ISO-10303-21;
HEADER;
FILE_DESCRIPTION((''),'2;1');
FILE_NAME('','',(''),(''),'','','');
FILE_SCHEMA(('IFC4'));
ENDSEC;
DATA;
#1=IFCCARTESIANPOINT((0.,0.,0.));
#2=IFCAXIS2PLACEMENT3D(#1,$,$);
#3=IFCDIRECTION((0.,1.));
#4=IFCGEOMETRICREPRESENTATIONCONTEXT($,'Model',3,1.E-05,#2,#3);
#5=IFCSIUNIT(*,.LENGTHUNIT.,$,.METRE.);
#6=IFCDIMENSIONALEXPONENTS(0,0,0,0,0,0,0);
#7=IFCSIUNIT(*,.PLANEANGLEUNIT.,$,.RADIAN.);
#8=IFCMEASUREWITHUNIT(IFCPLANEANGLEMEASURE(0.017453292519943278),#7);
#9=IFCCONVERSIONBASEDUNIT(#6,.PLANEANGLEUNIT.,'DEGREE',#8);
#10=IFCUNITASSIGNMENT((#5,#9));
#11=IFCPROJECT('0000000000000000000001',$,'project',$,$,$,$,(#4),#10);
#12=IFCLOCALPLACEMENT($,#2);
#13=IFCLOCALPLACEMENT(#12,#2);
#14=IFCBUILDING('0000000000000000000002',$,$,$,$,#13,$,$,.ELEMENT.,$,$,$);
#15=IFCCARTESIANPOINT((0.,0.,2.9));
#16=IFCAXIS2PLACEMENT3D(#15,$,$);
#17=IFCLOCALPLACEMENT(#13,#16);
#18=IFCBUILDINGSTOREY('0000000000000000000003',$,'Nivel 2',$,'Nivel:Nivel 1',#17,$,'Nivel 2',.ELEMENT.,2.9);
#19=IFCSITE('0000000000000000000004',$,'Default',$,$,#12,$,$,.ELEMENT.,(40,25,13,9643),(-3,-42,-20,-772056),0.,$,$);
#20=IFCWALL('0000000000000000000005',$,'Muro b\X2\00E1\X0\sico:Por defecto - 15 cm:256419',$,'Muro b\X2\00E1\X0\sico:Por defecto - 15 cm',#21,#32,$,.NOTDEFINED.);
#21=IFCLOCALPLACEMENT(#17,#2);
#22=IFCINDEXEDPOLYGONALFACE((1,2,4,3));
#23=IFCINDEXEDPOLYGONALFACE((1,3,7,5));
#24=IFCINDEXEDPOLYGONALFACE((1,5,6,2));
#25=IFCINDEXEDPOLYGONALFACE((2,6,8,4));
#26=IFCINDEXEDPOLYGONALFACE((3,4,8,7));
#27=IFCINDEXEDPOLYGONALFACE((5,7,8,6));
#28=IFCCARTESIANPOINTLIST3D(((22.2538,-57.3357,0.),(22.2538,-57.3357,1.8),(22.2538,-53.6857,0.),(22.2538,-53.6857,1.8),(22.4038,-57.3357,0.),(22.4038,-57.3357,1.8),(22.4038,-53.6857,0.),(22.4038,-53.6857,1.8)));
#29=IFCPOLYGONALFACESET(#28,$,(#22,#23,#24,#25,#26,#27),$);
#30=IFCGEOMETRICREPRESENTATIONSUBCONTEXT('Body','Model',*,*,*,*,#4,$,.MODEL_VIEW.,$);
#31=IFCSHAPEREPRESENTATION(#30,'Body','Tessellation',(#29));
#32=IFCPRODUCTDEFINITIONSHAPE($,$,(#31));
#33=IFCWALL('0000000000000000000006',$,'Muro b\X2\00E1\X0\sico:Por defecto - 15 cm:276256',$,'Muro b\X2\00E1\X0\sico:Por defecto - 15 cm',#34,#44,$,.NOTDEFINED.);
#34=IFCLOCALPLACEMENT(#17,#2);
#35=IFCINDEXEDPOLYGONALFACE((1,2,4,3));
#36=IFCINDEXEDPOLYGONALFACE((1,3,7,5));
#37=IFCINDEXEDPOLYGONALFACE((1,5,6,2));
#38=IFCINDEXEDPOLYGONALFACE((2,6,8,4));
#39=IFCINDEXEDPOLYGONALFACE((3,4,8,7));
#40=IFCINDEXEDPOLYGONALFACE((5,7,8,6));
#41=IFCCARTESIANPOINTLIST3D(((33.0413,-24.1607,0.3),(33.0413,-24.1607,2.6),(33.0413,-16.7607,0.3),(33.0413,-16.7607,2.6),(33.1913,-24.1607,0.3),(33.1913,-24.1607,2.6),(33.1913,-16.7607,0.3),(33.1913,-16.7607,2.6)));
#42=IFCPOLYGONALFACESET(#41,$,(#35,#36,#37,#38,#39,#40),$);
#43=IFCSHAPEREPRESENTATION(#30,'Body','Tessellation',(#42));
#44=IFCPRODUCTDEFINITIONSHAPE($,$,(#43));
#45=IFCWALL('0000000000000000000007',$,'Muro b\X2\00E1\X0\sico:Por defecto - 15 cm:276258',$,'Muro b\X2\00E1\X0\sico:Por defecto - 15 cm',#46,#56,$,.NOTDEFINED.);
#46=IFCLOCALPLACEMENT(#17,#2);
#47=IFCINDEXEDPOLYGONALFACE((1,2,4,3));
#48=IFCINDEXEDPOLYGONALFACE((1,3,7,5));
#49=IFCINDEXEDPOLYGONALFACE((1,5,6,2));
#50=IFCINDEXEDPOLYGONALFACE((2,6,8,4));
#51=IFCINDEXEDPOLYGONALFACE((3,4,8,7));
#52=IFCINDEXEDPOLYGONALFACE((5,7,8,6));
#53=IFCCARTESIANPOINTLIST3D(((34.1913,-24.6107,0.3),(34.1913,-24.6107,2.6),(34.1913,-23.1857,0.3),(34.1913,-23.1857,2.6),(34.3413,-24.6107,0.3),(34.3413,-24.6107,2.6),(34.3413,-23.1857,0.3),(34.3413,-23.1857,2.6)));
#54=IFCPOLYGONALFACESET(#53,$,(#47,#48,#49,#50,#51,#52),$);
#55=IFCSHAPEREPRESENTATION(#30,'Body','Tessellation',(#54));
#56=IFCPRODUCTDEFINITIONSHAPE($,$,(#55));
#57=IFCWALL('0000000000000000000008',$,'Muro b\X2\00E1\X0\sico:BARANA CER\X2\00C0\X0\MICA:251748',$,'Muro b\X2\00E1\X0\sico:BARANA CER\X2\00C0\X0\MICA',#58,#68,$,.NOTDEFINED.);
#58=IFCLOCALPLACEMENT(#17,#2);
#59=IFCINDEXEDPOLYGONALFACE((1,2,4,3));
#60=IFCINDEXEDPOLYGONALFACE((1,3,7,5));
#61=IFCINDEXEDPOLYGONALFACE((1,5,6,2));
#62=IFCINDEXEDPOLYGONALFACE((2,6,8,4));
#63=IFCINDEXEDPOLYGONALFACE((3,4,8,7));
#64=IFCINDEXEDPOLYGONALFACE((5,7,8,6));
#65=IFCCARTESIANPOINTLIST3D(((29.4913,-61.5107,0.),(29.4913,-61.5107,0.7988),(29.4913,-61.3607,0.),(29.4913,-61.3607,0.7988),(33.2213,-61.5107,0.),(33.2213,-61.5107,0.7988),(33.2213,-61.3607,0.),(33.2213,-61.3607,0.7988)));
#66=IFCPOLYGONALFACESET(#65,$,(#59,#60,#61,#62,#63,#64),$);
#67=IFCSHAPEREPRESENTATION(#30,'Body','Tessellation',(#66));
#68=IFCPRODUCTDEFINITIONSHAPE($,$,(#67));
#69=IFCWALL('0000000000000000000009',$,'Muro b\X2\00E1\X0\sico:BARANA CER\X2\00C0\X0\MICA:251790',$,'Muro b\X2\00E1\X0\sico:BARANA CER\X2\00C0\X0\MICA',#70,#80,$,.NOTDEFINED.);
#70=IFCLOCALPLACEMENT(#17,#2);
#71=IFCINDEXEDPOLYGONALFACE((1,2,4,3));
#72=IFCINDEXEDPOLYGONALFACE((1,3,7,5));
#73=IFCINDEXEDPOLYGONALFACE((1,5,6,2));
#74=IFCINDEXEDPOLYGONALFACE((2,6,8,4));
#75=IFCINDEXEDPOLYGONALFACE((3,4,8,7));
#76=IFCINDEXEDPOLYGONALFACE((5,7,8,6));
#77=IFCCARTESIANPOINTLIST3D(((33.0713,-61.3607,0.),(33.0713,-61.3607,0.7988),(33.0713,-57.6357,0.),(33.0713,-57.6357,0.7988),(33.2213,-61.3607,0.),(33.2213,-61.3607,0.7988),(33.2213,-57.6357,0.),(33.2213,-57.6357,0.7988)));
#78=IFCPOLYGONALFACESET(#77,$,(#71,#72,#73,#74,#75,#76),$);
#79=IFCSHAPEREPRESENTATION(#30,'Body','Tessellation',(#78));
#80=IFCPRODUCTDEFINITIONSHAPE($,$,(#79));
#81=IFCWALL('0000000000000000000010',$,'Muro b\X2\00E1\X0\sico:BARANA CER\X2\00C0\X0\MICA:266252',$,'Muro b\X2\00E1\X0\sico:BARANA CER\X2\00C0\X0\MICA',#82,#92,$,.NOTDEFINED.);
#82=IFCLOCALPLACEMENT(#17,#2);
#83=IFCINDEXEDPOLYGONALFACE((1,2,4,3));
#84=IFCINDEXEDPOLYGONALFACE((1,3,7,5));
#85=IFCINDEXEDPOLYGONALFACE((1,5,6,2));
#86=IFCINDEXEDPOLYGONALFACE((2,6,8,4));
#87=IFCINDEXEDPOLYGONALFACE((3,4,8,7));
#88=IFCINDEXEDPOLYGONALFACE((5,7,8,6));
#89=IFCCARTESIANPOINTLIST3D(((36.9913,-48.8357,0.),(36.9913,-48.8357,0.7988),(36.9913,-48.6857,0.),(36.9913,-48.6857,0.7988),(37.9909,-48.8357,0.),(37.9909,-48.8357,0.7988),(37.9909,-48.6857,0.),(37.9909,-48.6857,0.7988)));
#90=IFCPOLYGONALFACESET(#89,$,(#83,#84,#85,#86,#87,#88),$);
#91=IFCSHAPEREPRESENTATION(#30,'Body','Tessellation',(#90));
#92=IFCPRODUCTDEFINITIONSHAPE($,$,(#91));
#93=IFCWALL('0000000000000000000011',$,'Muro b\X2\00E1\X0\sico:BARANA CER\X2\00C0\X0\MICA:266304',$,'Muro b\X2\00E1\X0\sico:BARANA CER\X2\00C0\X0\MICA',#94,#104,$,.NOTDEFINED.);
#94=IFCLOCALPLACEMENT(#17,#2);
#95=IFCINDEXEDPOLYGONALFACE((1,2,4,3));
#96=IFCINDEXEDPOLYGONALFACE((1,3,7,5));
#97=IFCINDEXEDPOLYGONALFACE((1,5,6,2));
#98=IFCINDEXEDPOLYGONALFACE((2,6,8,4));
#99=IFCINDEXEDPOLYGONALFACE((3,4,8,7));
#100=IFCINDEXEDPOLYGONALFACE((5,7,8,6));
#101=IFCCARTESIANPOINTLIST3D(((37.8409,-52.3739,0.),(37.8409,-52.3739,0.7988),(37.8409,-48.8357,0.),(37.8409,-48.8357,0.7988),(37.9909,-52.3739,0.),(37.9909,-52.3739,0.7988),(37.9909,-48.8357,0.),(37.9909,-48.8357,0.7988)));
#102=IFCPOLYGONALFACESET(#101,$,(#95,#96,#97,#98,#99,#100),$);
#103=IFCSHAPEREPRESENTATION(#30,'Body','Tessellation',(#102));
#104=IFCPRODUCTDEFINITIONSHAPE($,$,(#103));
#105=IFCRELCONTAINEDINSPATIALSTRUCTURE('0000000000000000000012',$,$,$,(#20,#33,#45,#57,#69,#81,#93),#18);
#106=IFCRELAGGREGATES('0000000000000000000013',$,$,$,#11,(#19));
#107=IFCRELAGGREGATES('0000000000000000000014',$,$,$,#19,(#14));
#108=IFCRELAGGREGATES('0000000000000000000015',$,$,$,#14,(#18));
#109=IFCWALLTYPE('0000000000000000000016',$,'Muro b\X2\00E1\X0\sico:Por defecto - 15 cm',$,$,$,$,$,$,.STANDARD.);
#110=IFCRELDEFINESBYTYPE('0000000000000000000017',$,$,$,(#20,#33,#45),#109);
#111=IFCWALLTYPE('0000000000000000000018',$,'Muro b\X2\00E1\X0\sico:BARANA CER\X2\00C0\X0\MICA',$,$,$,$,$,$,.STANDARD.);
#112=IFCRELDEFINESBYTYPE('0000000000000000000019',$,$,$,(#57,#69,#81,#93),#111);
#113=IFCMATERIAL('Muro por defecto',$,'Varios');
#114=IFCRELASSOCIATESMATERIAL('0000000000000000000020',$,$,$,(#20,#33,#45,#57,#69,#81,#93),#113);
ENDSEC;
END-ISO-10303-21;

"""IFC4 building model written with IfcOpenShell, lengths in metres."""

from ifc_helpers import new_model, entity, si_unit, converted_unit, direction, frame, origin, place, context, subcontext, project, spatial, indexed_curve, outline, extrude, material, type_object, element, save


model = new_model("IFC4")

# Units and contexts
model_context = context("Model", 3, precision=1e-05, world=origin(), true_north=direction((0.0, 1.0)))
body_context = subcontext(model_context, "Body", "Model", "MODEL_VIEW")
ifc_project = project(units=[si_unit("LENGTHUNIT", "METRE"), converted_unit("PLANEANGLEUNIT", "DEGREE", entity("IfcPlaneAngleMeasure", 0.017453292519943278), si_unit("PLANEANGLEUNIT", "RADIAN"), dimensions=[0, 0, 0, 0, 0, 0, 0])], contexts=[model_context])

# Site, building, storey
site_placement = place(None, origin())
site = spatial("IfcSite", under=ifc_project, at=site_placement, Name="Default", CompositionType="ELEMENT", RefLatitude=(40, 25, 13, 9643), RefLongitude=(-3, -42, -20, -772056), RefElevation=0.0)
building_placement = place(site_placement, origin())
building = spatial("IfcBuilding", under=site, at=building_placement, CompositionType="ELEMENT")
storey_placement = place(building_placement, frame((0.0, 0.0, 2.9)))
storey = spatial("IfcBuildingStorey", under=building, at=storey_placement, Name="Nivel 2", ObjectType="Nivel:Nivel 1", LongName="Nivel 2", CompositionType="ELEMENT", Elevation=2.9)

# Walls
ifc_material_1 = material(Name="Muro por defecto", Category="Varios")
wall_type_1 = type_object("IfcWallType", Name="Muro básico:Por defecto - 15 cm", PredefinedType="STANDARD")
wall_1_placement = place(storey_placement, frame((22.3288, -57.3357, 0.0), z_axis=(0.0, 0.0, 1.0), x_axis=(0.0, 1.0, 0.0)))
element("IfcWall", 1, at=wall_1_placement, inside=storey, type_object=wall_type_1, material=ifc_material_1, Name="Muro básico:Por defecto - 15 cm:256419", ObjectType="Muro básico:Por defecto - 15 cm", PredefinedType="NOTDEFINED", context=body_context, shape_type="SweptSolid", body=[
    extrude(outline(indexed_curve([(3.65, 0.075), (0.0, 0.075), (0.0, -0.075), (3.65, -0.075), (3.65, 0.075)], self_intersect=False)), origin(), (0.0, 0.0, 1.0), 1.8),
])
wall_2_placement = place(storey_placement, frame((33.1163, -24.1607, 0.3), z_axis=(0.0, 0.0, 1.0), x_axis=(0.0, 1.0, 0.0)))
element("IfcWall", 2, at=wall_2_placement, inside=storey, type_object=wall_type_1, material=ifc_material_1, Name="Muro básico:Por defecto - 15 cm:276256", ObjectType="Muro básico:Por defecto - 15 cm", PredefinedType="NOTDEFINED", context=body_context, shape_type="SweptSolid", body=[
    extrude(outline(indexed_curve([(7.4, 0.075), (0.0, 0.075), (0.0, -0.075), (7.4, -0.075), (7.4, 0.075)], self_intersect=False)), origin(), (0.0, 0.0, 1.0), 2.3),
])
wall_3_placement = place(storey_placement, frame((34.2663, -23.1857, 0.3), z_axis=(0.0, 0.0, 1.0), x_axis=(0.0, -1.0, 0.0)))
element("IfcWall", 3, at=wall_3_placement, inside=storey, type_object=wall_type_1, material=ifc_material_1, Name="Muro básico:Por defecto - 15 cm:276258", ObjectType="Muro básico:Por defecto - 15 cm", PredefinedType="NOTDEFINED", context=body_context, shape_type="SweptSolid", body=[
    extrude(outline(indexed_curve([(1.425, 0.075), (0.0, 0.075), (0.0, -0.075), (1.425, -0.075), (1.425, 0.075)], self_intersect=False)), origin(), (0.0, 0.0, 1.0), 2.3),
])
wall_type_2 = type_object("IfcWallType", Name="Muro básico:BARANA CERÀMICA", PredefinedType="STANDARD")
wall_4_placement = place(storey_placement, frame((29.4913, -61.4357, 0.0)))
element("IfcWall", 4, at=wall_4_placement, inside=storey, type_object=wall_type_2, material=ifc_material_1, Name="Muro básico:BARANA CERÀMICA:251748", ObjectType="Muro básico:BARANA CERÀMICA", PredefinedType="NOTDEFINED", context=body_context, shape_type="SweptSolid", body=[
    extrude(outline(indexed_curve([(3.73, 0.075), (0.0, 0.075), (0.0, -0.075), (3.73, -0.075), (3.73, 0.075)], self_intersect=False)), origin(), (0.0, 0.0, 1.0), 0.7988),
])
wall_5_placement = place(storey_placement, frame((33.1463, -61.3607, 0.0), z_axis=(0.0, 0.0, 1.0), x_axis=(0.0, 1.0, 0.0)))
element("IfcWall", 5, at=wall_5_placement, inside=storey, type_object=wall_type_2, material=ifc_material_1, Name="Muro básico:BARANA CERÀMICA:251790", ObjectType="Muro básico:BARANA CERÀMICA", PredefinedType="NOTDEFINED", context=body_context, shape_type="SweptSolid", body=[
    extrude(outline(indexed_curve([(3.725, 0.075), (0.0, 0.075), (0.0, -0.075), (3.725, -0.075), (3.725, 0.075)], self_intersect=False)), origin(), (0.0, 0.0, 1.0), 0.7988),
])
wall_6_placement = place(storey_placement, frame((36.9913, -48.7607, 0.0)))
element("IfcWall", 6, at=wall_6_placement, inside=storey, type_object=wall_type_2, material=ifc_material_1, Name="Muro básico:BARANA CERÀMICA:266252", ObjectType="Muro básico:BARANA CERÀMICA", PredefinedType="NOTDEFINED", context=body_context, shape_type="SweptSolid", body=[
    extrude(outline(indexed_curve([(0.9996, 0.075), (0.0, 0.075), (0.0, -0.075), (0.9996, -0.075), (0.9996, 0.075)], self_intersect=False)), origin(), (0.0, 0.0, 1.0), 0.7988),
])
wall_7_placement = place(storey_placement, frame((37.9159, -48.8357, 0.0), z_axis=(0.0, 0.0, 1.0), x_axis=(0.0, -1.0, 0.0)))
element("IfcWall", 7, at=wall_7_placement, inside=storey, type_object=wall_type_2, material=ifc_material_1, Name="Muro básico:BARANA CERÀMICA:266304", ObjectType="Muro básico:BARANA CERÀMICA", PredefinedType="NOTDEFINED", context=body_context, shape_type="SweptSolid", body=[
    extrude(outline(indexed_curve([(3.5382, 0.075), (0.0, 0.075), (0.0, -0.075), (3.5382, -0.075), (3.5382, 0.075)], self_intersect=False)), origin(), (0.0, 0.0, 1.0), 0.7988),
])

save(model, "model.ifc")
